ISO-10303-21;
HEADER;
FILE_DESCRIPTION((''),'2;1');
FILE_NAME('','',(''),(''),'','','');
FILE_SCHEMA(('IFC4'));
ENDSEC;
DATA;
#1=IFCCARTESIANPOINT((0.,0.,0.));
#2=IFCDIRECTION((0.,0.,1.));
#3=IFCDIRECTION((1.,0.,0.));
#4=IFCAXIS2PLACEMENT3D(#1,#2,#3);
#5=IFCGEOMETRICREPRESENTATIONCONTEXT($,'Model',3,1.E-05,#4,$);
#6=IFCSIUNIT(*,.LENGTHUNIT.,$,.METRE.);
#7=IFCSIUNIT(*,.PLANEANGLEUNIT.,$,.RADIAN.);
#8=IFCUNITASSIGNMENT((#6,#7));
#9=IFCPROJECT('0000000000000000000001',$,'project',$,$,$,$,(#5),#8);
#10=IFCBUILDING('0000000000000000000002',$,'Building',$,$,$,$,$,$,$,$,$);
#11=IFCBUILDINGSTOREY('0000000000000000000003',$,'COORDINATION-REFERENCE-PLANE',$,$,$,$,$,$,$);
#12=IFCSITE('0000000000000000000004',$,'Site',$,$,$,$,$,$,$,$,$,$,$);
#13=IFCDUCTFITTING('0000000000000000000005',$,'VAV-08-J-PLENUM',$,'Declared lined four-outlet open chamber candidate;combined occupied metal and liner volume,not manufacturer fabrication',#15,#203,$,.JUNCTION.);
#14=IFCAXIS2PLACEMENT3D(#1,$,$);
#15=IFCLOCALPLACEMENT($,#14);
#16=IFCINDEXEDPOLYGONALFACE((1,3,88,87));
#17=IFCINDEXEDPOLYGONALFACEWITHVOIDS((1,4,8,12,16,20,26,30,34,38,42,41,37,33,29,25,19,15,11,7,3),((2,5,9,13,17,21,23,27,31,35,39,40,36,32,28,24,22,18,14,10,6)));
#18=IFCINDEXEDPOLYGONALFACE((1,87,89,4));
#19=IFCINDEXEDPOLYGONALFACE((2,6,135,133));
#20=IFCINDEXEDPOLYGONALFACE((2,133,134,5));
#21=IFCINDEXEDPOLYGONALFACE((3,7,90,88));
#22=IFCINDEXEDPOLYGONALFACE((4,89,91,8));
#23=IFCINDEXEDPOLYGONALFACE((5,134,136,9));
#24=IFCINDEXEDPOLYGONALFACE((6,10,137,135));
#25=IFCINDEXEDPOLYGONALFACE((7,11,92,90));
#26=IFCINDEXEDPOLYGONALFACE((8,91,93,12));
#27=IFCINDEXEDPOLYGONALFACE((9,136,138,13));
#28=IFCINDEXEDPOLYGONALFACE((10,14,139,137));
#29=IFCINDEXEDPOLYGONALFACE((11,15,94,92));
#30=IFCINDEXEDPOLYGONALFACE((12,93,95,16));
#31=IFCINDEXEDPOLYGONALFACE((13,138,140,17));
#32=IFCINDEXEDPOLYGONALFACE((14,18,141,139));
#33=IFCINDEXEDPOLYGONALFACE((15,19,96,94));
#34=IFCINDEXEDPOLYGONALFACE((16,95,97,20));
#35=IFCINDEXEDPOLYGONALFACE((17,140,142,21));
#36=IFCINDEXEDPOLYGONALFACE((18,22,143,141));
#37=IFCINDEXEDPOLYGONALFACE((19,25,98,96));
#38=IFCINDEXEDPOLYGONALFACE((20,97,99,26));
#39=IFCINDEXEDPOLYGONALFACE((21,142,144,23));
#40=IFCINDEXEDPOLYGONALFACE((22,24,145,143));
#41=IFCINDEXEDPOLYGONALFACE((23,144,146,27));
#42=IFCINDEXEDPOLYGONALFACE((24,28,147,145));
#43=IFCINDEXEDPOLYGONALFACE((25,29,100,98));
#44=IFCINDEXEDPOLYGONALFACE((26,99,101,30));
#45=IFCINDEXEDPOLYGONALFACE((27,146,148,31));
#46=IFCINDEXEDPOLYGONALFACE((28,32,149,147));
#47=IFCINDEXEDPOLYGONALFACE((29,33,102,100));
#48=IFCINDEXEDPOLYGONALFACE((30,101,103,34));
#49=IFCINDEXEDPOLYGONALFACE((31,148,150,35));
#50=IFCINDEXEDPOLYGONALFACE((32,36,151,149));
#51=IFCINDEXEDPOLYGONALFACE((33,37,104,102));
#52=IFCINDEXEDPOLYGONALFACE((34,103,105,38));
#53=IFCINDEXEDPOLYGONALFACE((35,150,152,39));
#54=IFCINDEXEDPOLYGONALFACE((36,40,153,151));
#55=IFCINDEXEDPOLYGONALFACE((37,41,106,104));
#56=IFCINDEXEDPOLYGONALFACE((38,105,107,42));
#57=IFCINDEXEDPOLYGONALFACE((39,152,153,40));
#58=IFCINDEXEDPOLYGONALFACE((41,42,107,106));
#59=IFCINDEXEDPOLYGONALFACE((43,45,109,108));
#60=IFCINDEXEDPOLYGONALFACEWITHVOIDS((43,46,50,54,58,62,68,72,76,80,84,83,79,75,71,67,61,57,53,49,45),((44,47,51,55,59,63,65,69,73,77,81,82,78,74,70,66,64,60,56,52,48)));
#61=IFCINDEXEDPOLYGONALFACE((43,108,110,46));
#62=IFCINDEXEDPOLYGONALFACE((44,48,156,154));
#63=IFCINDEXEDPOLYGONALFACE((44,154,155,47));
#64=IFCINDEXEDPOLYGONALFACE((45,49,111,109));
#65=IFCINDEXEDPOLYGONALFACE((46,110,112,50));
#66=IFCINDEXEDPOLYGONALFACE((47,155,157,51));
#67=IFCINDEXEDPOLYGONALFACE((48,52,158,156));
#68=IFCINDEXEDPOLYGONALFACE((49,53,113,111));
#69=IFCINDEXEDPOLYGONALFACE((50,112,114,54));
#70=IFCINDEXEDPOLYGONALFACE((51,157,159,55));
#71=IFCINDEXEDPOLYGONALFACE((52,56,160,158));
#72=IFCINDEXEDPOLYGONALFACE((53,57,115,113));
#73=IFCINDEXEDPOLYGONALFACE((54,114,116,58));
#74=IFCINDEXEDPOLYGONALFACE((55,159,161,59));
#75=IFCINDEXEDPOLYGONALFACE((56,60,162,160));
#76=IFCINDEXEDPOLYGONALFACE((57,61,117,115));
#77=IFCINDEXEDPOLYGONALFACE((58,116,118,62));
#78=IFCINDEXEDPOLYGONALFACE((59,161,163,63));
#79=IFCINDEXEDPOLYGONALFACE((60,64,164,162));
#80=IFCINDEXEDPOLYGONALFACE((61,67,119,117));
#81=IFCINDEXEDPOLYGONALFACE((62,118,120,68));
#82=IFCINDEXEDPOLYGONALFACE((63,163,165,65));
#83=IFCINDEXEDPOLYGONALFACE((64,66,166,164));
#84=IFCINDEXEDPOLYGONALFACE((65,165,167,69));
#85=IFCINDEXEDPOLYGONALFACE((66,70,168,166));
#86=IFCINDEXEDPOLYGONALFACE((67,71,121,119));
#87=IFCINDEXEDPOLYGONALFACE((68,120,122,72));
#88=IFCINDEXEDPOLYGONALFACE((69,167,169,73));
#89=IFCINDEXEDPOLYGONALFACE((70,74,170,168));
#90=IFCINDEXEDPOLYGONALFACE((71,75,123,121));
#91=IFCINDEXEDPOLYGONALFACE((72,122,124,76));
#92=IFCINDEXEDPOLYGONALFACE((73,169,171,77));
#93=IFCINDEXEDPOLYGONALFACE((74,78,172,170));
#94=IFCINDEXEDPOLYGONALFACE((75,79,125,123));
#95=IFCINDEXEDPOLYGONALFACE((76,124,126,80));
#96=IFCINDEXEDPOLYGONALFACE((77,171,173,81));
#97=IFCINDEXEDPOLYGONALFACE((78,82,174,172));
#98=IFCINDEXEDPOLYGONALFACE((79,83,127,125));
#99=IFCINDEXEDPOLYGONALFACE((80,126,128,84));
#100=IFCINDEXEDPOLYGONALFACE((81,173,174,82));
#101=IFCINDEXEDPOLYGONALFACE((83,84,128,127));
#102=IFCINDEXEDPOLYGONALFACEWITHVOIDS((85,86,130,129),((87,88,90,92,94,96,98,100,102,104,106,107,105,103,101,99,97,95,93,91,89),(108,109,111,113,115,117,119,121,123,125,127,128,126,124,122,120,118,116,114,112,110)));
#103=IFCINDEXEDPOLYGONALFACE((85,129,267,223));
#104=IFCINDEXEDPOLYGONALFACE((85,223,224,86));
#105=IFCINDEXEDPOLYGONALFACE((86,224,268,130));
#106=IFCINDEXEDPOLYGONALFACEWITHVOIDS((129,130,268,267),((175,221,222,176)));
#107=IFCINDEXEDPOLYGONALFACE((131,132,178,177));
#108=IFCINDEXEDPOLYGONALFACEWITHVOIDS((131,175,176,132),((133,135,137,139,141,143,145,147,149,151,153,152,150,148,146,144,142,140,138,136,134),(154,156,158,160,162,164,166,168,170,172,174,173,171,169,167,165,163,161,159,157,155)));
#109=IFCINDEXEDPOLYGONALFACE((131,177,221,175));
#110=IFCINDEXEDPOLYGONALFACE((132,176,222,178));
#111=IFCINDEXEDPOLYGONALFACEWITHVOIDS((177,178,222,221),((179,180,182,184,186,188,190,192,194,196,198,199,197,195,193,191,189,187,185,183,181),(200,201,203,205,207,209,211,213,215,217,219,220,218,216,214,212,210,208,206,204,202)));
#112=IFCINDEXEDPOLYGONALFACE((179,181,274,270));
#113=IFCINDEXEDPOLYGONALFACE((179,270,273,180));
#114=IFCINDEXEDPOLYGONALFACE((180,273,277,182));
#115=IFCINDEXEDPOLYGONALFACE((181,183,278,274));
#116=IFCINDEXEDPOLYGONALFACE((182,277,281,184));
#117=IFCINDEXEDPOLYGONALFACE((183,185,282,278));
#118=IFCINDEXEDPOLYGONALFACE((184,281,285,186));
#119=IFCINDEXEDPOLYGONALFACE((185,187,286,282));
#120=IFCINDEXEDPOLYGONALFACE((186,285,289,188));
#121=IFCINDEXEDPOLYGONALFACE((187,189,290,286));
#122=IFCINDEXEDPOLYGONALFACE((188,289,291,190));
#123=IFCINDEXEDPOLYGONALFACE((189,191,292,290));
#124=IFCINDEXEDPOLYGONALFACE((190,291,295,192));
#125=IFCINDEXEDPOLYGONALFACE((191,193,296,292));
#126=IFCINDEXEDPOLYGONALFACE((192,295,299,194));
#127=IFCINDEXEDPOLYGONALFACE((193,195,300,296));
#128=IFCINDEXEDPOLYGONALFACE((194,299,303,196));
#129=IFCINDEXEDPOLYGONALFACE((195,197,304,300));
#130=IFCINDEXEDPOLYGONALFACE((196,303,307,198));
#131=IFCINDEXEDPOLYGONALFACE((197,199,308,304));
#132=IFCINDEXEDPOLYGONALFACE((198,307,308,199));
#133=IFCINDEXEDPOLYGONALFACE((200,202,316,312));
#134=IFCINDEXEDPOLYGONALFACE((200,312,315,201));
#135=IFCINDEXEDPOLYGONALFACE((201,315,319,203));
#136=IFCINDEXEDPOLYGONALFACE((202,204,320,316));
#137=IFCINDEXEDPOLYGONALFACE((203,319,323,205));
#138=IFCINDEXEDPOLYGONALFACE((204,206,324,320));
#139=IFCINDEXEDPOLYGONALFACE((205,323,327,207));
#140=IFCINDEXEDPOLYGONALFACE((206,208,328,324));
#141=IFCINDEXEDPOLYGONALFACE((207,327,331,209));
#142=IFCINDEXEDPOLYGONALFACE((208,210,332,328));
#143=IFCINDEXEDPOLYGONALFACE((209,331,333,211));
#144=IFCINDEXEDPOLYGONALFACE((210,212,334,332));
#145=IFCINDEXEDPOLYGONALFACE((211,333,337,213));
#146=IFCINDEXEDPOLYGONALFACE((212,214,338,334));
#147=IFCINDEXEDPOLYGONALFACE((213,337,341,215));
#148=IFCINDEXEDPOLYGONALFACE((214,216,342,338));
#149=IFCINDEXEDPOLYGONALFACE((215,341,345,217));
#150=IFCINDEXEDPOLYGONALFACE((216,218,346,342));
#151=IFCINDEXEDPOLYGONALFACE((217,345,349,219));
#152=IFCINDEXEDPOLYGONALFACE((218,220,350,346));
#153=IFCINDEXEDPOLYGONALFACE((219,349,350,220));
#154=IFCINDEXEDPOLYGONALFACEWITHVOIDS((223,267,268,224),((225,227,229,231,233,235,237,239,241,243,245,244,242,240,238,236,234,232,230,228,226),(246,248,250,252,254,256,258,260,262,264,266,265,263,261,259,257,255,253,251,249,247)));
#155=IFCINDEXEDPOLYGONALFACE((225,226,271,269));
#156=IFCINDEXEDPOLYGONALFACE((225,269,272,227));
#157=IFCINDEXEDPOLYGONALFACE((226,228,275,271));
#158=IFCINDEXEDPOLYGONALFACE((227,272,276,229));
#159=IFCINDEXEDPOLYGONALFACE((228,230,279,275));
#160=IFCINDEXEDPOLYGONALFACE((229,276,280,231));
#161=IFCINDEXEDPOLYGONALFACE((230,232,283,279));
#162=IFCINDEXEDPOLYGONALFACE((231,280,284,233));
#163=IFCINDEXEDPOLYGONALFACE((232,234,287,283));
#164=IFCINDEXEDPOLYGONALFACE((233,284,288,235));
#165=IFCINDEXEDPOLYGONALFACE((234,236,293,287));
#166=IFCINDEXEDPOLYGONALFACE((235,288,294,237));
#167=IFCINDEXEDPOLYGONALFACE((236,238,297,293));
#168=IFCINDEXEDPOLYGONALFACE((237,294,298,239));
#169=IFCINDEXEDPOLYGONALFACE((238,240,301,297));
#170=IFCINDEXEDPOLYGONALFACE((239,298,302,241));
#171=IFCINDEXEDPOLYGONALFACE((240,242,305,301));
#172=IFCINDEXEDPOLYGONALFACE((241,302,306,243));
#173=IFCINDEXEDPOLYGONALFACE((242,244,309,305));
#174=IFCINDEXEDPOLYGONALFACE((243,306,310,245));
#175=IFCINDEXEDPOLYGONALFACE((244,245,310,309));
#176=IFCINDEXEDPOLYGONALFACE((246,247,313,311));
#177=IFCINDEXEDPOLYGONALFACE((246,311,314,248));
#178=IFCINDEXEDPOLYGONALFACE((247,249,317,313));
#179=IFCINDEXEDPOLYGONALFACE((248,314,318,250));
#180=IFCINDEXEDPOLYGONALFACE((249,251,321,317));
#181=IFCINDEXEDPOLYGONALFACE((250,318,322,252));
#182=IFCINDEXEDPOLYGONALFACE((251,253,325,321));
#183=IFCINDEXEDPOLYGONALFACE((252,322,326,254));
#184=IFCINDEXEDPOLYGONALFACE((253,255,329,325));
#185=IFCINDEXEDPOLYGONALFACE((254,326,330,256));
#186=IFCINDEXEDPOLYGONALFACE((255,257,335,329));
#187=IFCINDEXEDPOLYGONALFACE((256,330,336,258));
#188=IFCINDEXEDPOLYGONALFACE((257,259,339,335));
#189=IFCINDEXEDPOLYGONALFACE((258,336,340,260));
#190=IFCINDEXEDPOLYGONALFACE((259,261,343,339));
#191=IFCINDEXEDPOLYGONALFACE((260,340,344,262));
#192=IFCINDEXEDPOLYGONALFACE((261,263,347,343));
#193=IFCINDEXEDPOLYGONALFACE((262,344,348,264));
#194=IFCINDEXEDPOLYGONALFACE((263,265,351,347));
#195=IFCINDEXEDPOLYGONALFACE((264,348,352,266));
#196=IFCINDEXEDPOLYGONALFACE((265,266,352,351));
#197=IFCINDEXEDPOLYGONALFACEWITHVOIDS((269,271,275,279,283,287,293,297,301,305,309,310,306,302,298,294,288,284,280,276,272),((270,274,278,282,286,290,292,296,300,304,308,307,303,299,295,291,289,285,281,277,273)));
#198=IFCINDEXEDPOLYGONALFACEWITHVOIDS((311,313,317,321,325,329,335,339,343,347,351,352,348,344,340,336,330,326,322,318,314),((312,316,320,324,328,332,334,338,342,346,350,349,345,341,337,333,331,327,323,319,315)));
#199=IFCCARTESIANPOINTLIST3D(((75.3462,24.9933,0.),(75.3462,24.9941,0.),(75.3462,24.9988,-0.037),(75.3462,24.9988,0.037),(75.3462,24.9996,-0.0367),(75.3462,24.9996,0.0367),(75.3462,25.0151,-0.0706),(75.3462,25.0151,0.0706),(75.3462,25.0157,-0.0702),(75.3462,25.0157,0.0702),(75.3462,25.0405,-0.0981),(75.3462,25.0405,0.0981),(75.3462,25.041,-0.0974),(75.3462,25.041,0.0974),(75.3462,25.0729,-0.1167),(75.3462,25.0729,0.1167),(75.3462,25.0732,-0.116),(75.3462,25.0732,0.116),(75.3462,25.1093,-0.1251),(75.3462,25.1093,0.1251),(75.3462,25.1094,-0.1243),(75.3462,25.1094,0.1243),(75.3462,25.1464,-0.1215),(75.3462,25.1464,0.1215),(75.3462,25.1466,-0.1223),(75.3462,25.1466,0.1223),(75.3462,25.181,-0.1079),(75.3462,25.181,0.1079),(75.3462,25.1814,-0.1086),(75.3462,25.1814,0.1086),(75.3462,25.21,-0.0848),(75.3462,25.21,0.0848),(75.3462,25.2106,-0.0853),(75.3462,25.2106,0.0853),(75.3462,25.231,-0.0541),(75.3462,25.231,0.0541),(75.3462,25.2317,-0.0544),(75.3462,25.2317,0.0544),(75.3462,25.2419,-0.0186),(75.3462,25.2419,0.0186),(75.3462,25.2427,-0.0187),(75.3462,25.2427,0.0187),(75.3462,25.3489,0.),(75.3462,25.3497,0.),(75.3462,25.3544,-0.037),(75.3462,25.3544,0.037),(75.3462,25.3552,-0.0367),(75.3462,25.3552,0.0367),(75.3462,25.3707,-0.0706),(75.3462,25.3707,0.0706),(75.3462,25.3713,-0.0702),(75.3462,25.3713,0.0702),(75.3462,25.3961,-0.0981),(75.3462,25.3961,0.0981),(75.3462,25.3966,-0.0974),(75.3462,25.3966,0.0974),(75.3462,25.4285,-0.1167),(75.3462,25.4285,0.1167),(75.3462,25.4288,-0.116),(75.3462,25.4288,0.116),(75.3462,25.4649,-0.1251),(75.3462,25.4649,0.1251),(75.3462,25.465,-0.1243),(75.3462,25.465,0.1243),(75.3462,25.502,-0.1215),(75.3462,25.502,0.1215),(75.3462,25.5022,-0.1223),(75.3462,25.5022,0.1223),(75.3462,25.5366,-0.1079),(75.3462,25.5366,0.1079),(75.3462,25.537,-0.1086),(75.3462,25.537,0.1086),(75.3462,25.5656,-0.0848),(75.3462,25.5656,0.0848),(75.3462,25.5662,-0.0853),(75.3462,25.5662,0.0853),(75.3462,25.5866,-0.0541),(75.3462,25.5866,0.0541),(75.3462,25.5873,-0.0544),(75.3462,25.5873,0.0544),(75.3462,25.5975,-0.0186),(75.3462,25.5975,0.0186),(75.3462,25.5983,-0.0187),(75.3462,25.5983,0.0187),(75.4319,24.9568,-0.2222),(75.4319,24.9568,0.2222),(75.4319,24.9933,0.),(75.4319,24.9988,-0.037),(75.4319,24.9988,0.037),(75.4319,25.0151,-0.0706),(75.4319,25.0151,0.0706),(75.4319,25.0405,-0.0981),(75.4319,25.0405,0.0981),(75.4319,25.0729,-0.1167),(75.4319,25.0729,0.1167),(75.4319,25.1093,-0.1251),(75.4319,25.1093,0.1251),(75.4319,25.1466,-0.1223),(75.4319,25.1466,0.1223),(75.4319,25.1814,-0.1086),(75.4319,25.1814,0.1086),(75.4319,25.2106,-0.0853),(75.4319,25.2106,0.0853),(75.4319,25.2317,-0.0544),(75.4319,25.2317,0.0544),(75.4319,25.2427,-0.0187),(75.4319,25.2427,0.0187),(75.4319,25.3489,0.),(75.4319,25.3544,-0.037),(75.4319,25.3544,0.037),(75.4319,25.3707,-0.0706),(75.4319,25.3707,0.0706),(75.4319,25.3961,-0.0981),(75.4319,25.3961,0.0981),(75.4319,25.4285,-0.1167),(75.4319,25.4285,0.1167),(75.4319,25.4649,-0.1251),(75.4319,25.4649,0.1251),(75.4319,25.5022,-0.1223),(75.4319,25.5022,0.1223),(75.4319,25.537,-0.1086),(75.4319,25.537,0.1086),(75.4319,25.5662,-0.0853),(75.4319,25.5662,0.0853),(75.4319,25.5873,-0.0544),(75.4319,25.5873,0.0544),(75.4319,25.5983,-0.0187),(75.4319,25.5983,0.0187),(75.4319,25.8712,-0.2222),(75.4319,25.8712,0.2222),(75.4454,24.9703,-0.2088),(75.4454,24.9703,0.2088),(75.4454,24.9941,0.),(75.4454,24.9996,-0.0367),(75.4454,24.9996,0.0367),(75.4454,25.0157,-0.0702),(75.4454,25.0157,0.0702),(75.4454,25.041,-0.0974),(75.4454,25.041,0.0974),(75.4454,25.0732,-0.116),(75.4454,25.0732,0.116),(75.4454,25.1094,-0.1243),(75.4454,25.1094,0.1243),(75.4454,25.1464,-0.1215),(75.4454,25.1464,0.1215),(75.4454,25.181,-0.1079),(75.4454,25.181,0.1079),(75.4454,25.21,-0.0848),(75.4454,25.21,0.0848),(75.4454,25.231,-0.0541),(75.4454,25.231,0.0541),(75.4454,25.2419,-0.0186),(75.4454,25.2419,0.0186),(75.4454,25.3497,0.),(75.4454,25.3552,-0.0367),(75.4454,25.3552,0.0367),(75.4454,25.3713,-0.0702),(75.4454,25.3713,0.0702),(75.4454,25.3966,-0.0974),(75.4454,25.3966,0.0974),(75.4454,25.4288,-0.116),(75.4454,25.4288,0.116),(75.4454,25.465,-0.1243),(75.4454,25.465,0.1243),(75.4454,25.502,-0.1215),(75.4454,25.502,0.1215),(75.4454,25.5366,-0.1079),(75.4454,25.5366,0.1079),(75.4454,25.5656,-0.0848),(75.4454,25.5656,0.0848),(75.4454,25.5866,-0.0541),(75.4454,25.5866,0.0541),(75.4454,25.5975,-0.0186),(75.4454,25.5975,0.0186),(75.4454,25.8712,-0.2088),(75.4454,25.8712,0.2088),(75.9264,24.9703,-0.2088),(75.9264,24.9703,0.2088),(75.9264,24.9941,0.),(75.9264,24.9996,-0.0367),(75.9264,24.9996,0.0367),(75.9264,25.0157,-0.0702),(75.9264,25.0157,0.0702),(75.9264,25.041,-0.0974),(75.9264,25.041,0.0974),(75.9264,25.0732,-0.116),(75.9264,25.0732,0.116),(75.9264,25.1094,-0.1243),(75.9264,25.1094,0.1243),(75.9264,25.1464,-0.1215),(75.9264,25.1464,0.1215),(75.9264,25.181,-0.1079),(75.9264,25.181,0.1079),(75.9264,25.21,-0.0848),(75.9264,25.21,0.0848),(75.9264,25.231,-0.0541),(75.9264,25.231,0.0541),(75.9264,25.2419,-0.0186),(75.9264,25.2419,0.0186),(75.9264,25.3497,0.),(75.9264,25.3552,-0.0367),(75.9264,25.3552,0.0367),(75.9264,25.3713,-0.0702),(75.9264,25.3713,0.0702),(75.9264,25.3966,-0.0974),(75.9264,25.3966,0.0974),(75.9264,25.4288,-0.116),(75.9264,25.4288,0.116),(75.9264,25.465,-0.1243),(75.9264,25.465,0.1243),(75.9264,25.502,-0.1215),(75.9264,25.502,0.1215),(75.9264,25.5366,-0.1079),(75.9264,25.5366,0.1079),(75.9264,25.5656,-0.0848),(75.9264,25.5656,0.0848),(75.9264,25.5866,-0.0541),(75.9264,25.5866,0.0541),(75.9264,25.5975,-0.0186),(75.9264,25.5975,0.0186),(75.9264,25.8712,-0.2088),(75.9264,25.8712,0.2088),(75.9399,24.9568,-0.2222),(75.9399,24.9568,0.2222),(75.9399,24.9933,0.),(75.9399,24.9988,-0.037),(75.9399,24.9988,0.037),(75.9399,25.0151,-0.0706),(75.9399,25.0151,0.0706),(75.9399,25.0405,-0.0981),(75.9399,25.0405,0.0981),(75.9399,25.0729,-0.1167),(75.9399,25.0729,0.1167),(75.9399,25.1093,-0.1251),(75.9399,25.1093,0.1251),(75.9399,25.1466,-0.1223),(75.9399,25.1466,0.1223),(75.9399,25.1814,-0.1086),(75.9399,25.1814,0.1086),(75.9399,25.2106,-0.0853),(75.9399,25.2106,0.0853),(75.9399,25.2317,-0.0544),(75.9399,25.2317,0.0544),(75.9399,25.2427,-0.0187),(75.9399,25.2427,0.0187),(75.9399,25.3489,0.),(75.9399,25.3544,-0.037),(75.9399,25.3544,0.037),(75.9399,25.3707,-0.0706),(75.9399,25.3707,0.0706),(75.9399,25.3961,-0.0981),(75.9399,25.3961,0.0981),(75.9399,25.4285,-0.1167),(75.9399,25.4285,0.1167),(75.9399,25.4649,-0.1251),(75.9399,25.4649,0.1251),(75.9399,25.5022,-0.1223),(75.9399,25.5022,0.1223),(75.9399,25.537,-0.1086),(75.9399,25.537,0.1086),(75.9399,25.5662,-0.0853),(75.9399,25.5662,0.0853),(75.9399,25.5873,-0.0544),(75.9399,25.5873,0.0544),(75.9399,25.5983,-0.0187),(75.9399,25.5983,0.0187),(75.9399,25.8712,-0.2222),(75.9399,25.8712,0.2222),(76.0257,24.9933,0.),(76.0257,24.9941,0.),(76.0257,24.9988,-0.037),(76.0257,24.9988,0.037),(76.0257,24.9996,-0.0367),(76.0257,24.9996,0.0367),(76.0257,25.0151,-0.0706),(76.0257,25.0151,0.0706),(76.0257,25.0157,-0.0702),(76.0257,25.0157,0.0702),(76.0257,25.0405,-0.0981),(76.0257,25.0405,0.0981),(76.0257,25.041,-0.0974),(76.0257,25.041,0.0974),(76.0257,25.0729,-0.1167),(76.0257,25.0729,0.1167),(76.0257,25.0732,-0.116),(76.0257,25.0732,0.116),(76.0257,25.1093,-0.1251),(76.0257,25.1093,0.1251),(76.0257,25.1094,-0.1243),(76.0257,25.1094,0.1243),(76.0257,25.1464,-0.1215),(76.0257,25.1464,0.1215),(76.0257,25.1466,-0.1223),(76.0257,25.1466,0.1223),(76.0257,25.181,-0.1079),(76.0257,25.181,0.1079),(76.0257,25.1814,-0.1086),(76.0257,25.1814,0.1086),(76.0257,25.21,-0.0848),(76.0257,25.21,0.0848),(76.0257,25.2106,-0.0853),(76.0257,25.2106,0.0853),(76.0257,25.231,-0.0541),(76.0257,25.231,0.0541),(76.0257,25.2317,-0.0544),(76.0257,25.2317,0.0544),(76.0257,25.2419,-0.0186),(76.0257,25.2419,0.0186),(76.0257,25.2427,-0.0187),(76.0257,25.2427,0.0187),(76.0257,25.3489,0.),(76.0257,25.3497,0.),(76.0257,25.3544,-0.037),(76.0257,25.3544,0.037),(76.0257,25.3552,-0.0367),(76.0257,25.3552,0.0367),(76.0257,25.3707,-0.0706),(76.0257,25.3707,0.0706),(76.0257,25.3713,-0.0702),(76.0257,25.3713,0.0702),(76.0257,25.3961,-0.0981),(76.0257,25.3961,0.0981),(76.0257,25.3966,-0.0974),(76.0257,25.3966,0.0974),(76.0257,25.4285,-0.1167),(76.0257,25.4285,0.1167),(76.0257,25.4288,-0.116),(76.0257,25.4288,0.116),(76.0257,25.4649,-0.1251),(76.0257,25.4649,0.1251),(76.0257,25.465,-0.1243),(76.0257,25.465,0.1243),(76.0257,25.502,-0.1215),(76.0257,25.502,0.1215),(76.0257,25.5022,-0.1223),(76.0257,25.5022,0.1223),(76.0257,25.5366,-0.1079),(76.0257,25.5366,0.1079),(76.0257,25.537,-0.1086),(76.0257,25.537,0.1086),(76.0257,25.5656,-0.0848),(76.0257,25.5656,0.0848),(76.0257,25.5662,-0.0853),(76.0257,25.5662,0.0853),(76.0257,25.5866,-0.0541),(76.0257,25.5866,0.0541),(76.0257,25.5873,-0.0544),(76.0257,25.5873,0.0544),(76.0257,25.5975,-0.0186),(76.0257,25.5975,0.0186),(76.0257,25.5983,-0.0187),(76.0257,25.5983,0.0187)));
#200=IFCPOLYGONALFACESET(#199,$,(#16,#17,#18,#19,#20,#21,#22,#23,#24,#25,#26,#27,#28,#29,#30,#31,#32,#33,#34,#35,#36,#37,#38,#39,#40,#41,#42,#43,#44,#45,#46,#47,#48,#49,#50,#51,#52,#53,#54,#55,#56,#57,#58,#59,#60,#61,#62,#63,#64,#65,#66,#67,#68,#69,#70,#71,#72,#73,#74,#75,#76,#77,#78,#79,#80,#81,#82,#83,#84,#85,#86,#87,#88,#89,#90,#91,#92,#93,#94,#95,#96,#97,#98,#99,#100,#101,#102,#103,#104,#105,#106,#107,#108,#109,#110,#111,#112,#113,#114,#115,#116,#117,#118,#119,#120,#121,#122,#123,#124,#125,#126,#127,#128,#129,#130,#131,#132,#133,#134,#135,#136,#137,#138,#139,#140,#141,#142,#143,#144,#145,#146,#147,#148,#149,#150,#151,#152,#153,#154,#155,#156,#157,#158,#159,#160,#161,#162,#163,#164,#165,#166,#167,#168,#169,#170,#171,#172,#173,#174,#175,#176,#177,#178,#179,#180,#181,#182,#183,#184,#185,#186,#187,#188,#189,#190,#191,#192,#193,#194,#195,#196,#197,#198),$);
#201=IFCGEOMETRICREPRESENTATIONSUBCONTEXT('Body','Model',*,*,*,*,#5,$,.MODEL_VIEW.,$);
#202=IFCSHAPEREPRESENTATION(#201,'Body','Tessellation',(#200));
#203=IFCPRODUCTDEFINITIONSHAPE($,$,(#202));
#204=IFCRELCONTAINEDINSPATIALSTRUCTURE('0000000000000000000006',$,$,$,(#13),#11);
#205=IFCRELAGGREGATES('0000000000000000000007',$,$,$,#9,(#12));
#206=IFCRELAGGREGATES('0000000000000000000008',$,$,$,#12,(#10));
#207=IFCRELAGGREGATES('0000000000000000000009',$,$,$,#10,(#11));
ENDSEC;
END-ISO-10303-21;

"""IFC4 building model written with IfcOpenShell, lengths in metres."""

from ifc_helpers import new_model, si_unit, frame, origin_with_axes, place, context, subcontext, project, spatial, rectangle, circle, extrude, boolean, element, save


model = new_model("IFC4")

# Units and contexts
model_context = context("Model", 3, precision=1e-05, world=origin_with_axes())
body_context_1 = subcontext(model_context, "Body", "Model", "MODEL_VIEW")
ifc_project = project(units=[si_unit("LENGTHUNIT", "METRE"), si_unit("PLANEANGLEUNIT", "RADIAN")], contexts=[model_context])

# Site, building, storey
site = spatial("IfcSite", under=ifc_project, Name="Site")
building = spatial("IfcBuilding", under=site, Name="Building")
storey = spatial("IfcBuildingStorey", under=building, Name="COORDINATION-REFERENCE-PLANE")

# Duct fitting
duct_fitting_1_placement = place(None, frame((75.4319, 24.9568, -0.2223), z_axis=(0.0, 0.0, 1.0), x_axis=(1.0, 0.0, 0.0)))
solid_1 = boolean("UNION", boolean("UNION", boolean("UNION", boolean("UNION", extrude(rectangle(XDim=0.481, YDim=0.4175), frame((0.254, 0.9244, 0.2223), z_axis=(0.0, -1.0, 0.0), x_axis=(1.0, 0.0, 0.0)), (0.0, 0.0, 1.0), 0.9109), extrude(circle(Radius=0.1246), frame((0.0235, 0.5175, 0.2223), z_axis=(-1.0, 0.0, 0.0), x_axis=(0.0, -1.0, 0.0)), (0.0, 0.0, 1.0), 0.1192)), extrude(circle(Radius=0.1246), frame((0.4845, 0.5175, 0.2223), z_axis=(1.0, 0.0, 0.0), x_axis=(0.0, -1.0, 0.0)), (0.0, 0.0, 1.0), 0.1192)), extrude(circle(Radius=0.1246), frame((0.0235, 0.1619, 0.2223), z_axis=(-1.0, 0.0, 0.0), x_axis=(0.0, -1.0, 0.0)), (0.0, 0.0, 1.0), 0.1192)), extrude(circle(Radius=0.1246), frame((0.4845, 0.1619, 0.2223), z_axis=(1.0, 0.0, 0.0), x_axis=(0.0, -1.0, 0.0)), (0.0, 0.0, 1.0), 0.1192))
element("IfcDuctFitting", 1, at=duct_fitting_1_placement, inside=storey, Name="VAV-08-J-PLENUM", ObjectType="Declared lined four-outlet open chamber candidate;combined occupied metal and liner volume,not manufacturer fabrication", PredefinedType="JUNCTION", context=body_context_1, shape_type="CSG", body=[
    boolean("DIFFERENCE", boolean("UNION", boolean("UNION", boolean("UNION", boolean("UNION", extrude(rectangle(XDim=0.508, YDim=0.4445), frame((0.254, 0.9144, 0.2223), z_axis=(0.0, -1.0, 0.0), x_axis=(1.0, 0.0, 0.0)), (0.0, 0.0, 1.0), 0.9144), extrude(circle(Radius=0.1254), frame((0.0235, 0.5175, 0.2223), z_axis=(-1.0, 0.0, 0.0), x_axis=(0.0, -1.0, 0.0)), (0.0, 0.0, 1.0), 0.1092)), extrude(circle(Radius=0.1254), frame((0.4845, 0.5175, 0.2223), z_axis=(1.0, 0.0, 0.0), x_axis=(0.0, -1.0, 0.0)), (0.0, 0.0, 1.0), 0.1092)), extrude(circle(Radius=0.1254), frame((0.0235, 0.1619, 0.2223), z_axis=(-1.0, 0.0, 0.0), x_axis=(0.0, -1.0, 0.0)), (0.0, 0.0, 1.0), 0.1092)), extrude(circle(Radius=0.1254), frame((0.4845, 0.1619, 0.2223), z_axis=(1.0, 0.0, 0.0), x_axis=(0.0, -1.0, 0.0)), (0.0, 0.0, 1.0), 0.1092)), solid_1),
])

save(model, "model.ifc")
